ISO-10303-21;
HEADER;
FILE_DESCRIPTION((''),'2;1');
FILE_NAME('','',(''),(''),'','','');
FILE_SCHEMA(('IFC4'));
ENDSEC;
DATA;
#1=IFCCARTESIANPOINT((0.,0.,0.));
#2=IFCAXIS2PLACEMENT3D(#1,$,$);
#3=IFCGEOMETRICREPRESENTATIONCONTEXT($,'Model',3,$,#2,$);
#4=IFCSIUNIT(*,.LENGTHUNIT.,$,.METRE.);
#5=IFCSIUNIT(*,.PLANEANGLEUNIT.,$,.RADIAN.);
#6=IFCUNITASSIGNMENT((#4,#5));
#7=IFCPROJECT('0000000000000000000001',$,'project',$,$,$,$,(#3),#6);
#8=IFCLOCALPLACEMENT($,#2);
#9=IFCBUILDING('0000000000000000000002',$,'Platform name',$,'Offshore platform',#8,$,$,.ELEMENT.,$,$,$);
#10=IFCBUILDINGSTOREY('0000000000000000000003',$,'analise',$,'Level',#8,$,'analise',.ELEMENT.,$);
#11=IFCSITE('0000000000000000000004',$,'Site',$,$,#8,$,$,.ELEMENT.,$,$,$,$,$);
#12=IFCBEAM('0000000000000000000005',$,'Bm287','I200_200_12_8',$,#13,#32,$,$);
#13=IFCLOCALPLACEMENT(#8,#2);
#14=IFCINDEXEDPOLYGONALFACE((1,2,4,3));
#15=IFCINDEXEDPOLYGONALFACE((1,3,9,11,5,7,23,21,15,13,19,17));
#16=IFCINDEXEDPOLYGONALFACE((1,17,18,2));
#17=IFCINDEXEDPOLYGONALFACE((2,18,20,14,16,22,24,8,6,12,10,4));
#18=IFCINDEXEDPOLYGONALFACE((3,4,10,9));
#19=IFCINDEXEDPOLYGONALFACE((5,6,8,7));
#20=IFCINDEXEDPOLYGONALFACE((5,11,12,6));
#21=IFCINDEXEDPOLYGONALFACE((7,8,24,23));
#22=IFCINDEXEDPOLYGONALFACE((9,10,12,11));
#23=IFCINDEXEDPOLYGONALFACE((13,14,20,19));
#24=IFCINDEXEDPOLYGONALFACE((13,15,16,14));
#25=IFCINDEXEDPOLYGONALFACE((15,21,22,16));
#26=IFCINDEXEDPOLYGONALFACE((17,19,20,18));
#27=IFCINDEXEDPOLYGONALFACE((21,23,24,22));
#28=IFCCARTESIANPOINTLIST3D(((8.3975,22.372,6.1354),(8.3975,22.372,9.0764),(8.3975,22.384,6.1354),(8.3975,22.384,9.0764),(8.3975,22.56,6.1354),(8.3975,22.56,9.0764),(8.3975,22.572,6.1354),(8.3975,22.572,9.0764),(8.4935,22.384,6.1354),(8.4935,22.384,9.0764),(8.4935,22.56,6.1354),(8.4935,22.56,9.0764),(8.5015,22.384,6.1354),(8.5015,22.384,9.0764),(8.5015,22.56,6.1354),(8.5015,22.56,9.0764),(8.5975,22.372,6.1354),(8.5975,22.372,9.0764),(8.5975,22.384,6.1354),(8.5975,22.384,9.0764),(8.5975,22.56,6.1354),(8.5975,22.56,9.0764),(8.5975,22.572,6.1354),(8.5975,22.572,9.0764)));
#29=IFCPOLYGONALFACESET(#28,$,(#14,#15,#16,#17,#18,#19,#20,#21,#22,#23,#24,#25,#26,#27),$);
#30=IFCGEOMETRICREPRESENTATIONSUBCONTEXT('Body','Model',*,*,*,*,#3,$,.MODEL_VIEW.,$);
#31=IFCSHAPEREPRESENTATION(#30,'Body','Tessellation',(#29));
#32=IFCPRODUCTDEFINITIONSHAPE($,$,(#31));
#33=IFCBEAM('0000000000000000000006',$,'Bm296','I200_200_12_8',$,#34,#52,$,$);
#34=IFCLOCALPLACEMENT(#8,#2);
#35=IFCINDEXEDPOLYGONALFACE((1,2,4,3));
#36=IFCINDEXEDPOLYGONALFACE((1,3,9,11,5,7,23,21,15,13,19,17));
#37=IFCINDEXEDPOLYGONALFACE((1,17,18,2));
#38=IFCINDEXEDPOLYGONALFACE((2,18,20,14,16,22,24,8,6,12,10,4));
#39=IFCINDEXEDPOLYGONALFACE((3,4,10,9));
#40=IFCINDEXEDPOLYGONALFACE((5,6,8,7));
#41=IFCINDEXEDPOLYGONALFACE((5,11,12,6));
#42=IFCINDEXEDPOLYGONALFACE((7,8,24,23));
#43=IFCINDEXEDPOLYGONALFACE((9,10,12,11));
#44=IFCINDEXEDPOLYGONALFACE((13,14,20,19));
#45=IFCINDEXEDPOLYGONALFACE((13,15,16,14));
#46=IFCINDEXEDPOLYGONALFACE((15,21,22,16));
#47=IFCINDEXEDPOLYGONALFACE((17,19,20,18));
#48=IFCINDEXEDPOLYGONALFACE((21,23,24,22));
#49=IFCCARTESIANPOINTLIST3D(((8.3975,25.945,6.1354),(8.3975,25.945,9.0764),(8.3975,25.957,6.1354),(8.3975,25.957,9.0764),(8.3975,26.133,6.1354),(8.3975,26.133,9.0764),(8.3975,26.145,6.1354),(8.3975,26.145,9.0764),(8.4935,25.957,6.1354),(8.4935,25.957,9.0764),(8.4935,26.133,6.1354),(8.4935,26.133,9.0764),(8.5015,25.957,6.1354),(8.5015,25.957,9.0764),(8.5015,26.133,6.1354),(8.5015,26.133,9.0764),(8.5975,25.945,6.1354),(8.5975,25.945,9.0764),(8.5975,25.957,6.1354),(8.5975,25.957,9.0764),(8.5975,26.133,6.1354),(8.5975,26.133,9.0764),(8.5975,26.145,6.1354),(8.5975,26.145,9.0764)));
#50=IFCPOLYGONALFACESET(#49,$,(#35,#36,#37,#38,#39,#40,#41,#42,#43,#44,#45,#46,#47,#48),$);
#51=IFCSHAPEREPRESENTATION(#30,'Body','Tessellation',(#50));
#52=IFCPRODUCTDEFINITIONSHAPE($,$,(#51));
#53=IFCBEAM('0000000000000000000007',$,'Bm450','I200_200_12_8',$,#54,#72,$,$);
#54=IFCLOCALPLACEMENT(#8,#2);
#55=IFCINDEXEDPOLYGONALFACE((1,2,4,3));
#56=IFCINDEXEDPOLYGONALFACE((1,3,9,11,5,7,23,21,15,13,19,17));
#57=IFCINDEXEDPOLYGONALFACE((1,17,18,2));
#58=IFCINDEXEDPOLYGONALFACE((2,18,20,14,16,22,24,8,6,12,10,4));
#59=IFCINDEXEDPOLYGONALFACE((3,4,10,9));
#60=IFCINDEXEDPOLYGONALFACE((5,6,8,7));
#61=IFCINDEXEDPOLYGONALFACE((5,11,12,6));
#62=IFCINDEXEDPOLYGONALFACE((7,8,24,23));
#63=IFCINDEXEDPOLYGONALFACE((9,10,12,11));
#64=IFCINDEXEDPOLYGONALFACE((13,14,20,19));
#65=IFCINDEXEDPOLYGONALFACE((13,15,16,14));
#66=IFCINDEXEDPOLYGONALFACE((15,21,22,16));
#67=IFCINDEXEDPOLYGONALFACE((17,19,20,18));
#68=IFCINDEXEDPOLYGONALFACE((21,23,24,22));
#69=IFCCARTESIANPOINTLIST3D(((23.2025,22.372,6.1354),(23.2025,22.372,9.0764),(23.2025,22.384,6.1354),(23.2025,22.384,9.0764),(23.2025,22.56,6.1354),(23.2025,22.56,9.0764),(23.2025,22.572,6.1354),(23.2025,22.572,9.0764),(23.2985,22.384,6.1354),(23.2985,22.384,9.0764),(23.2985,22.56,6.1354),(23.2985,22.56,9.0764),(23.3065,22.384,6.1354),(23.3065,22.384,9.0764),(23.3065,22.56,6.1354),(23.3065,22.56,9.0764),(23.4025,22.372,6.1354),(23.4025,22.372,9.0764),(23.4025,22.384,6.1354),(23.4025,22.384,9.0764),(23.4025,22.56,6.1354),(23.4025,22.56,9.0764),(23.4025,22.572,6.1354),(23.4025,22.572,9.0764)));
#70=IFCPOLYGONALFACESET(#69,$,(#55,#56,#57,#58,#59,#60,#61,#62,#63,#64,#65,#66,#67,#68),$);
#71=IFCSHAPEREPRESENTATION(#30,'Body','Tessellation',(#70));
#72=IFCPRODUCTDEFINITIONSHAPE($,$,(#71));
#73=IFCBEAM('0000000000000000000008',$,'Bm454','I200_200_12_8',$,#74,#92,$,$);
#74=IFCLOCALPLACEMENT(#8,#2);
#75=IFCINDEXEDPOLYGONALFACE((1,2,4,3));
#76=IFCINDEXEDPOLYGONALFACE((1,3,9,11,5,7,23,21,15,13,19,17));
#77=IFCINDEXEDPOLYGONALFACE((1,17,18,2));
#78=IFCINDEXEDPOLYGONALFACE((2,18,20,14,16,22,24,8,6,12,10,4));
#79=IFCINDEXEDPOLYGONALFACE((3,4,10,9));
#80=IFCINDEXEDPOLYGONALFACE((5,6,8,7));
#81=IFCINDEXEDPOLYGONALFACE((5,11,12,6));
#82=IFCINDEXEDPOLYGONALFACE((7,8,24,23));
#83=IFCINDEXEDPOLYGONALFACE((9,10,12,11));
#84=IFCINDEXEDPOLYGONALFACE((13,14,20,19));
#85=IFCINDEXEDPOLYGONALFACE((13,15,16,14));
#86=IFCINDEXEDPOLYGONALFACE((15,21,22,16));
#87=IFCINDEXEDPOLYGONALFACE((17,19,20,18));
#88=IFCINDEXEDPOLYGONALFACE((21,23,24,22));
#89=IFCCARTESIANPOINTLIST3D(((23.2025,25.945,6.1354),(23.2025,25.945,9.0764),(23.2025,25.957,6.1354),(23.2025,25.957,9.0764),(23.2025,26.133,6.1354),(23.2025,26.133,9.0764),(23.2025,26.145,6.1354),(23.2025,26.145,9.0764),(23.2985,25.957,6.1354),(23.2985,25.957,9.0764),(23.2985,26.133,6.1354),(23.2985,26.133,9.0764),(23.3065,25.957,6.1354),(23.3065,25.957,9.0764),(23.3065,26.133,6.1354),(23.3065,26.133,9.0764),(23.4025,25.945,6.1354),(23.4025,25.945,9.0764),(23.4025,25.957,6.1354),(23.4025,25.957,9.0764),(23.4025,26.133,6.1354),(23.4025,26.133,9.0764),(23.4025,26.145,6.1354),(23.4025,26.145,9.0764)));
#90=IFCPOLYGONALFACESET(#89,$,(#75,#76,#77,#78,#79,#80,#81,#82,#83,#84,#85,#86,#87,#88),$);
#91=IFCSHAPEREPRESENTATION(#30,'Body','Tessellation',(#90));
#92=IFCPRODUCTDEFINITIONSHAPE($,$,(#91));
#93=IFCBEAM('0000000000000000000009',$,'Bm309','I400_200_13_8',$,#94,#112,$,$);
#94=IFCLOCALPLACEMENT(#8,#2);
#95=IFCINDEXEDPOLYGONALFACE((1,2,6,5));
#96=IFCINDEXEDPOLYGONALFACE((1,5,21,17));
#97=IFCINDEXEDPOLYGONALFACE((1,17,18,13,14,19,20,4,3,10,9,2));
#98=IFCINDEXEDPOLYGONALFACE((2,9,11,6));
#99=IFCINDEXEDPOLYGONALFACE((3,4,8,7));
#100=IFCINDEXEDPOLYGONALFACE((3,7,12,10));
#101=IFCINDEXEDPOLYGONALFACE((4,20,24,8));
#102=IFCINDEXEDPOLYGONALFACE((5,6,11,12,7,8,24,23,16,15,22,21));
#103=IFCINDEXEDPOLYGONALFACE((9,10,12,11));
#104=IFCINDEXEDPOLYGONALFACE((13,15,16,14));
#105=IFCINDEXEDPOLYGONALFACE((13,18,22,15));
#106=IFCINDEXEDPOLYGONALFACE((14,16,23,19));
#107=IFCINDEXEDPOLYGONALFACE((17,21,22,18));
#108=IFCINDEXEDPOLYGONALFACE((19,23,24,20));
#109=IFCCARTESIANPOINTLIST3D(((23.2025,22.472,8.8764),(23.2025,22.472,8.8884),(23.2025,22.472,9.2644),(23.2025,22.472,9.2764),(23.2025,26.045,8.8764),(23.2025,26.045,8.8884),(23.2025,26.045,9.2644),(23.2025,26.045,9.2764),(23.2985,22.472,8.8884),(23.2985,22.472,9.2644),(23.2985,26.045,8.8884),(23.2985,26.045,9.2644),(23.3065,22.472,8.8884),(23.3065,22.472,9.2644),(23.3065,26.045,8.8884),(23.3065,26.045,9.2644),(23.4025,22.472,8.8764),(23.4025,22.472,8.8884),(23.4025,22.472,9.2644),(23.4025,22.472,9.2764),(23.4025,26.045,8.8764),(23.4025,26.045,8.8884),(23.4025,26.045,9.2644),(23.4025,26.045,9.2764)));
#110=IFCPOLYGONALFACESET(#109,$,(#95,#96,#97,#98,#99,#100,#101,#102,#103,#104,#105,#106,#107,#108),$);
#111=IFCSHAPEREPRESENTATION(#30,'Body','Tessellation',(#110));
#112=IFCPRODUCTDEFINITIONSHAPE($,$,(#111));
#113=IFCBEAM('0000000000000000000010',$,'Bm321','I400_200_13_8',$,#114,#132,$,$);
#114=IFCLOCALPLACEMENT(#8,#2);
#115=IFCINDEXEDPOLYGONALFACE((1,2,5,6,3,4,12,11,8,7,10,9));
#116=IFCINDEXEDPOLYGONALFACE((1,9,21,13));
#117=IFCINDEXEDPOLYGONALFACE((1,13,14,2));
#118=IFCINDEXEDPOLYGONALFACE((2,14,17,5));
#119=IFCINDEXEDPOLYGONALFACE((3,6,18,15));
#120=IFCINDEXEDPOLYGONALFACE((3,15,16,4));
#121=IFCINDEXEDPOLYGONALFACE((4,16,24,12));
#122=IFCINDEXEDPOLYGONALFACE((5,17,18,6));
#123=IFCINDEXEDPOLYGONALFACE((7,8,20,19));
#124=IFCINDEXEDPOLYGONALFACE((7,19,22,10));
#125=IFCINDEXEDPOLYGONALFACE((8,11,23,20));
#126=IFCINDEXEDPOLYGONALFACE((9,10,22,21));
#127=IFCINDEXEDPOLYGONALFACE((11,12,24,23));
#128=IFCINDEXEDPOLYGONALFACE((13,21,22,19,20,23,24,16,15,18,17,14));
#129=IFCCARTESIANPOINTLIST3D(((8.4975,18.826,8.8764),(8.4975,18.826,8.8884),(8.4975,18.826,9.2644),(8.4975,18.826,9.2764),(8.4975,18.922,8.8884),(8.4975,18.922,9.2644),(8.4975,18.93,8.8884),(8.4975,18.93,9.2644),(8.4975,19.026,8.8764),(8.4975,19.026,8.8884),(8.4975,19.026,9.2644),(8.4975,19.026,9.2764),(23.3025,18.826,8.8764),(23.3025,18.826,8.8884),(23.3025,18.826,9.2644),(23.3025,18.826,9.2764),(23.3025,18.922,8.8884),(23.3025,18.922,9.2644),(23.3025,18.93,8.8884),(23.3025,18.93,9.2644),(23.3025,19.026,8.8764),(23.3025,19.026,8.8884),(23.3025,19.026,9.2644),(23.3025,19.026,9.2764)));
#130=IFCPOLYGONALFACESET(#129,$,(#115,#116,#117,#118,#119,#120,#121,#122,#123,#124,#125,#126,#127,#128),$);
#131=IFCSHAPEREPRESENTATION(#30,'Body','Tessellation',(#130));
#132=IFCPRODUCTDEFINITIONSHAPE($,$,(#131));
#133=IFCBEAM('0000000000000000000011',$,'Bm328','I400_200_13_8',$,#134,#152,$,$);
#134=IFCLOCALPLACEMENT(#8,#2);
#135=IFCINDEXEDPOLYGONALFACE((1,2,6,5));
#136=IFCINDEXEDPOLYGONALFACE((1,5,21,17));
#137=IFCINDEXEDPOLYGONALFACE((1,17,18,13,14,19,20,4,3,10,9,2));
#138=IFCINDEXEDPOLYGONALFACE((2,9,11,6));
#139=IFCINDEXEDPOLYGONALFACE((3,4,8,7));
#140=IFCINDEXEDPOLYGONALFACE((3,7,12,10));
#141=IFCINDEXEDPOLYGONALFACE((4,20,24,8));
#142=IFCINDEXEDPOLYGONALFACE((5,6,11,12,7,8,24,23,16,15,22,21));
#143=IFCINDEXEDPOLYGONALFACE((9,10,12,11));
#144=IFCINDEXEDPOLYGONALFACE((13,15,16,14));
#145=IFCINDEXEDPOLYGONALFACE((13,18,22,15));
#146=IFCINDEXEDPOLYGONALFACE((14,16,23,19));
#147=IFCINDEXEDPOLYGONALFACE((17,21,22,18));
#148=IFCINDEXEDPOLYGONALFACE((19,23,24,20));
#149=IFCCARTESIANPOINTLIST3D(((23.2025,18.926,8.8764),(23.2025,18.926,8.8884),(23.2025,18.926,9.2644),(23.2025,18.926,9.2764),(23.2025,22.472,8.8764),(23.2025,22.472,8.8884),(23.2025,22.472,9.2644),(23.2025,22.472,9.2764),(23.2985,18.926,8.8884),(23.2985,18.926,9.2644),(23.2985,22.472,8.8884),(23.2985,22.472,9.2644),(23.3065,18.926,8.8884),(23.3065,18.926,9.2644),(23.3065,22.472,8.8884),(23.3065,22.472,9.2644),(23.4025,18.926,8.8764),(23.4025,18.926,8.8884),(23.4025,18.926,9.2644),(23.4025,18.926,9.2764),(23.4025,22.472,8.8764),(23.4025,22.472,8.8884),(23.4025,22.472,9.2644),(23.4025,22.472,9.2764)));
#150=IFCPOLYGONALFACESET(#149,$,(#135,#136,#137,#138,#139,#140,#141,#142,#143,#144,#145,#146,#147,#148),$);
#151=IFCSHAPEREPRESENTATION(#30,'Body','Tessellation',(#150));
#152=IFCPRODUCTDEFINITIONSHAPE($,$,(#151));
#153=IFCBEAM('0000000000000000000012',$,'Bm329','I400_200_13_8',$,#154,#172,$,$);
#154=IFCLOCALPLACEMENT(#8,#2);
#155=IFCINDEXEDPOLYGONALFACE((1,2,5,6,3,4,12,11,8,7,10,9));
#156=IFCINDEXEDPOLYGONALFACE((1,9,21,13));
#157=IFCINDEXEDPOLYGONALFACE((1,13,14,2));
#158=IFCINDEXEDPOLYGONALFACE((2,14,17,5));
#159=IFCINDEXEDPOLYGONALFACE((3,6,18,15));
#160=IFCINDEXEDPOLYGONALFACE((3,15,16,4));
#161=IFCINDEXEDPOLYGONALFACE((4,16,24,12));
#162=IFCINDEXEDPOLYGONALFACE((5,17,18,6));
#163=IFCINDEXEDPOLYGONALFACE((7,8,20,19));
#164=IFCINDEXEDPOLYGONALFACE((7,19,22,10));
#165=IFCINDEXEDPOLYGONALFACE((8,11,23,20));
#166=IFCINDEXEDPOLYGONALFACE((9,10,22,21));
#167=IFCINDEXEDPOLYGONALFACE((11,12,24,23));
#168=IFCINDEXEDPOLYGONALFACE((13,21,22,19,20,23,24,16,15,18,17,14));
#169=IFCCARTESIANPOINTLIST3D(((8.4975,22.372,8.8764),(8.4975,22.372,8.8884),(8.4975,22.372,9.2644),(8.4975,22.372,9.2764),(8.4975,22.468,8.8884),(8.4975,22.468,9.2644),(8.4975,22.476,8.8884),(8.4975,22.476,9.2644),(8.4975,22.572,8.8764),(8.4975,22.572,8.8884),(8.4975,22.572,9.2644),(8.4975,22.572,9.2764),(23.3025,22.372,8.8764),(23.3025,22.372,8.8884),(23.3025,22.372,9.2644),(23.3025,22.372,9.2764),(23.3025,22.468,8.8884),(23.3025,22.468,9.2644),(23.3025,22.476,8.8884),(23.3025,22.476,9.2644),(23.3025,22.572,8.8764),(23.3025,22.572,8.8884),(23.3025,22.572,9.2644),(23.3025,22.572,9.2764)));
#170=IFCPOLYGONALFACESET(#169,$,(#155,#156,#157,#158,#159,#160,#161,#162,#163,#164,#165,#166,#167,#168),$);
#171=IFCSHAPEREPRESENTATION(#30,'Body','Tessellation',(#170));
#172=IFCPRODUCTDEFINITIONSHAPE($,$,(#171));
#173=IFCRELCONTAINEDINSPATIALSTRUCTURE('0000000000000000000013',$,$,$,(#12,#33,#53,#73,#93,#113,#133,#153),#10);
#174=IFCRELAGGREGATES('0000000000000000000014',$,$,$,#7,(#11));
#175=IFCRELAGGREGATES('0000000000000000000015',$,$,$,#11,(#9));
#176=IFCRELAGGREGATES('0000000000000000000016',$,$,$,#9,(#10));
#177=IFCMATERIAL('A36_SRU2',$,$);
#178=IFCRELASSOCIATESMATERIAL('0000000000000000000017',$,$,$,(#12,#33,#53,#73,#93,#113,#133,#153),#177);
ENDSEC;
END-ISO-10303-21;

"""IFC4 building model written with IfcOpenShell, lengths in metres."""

from ifc_helpers import new_model, si_unit, frame, origin, origin_with_axes, origin_2d, place, context, subcontext, project, spatial, i_section, extrude, source, transform, mapped, material, element, save


model = new_model("IFC4")

# Units and contexts
model_context = context("Model", 3, world=origin())
body_context = subcontext(model_context, "Body", "Model", "MODEL_VIEW")
ifc_project = project(units=[si_unit("LENGTHUNIT", "METRE"), si_unit("PLANEANGLEUNIT", "RADIAN")], contexts=[model_context])

# Site, building, storey
placement_1 = place(None, origin())
site = spatial("IfcSite", under=ifc_project, at=placement_1, Name="Site", CompositionType="ELEMENT")
building = spatial("IfcBuilding", under=site, at=placement_1, Name="Platform name", ObjectType="Offshore platform", CompositionType="ELEMENT")
storey = spatial("IfcBuildingStorey", under=building, at=placement_1, Name="analise", ObjectType="Level", LongName="analise", CompositionType="ELEMENT")

# Beams
ifc_material_1 = material(Name="A36_SRU2")
shared_shape_1 = source(origin(), body_context, "Body", "SweptSolid", [
    extrude(i_section(OverallWidth=0.2, OverallDepth=0.2, WebThickness=0.008, FlangeThickness=0.012, FilletRadius=0.0, at=origin_2d()), origin_with_axes(), (0.0, 0.0, 1.0), 2.941),
])
placement_2 = place(None, origin())
placement_3 = place(placement_2, origin())
placement_4 = place(placement_3, origin())
beam_1_placement = place(placement_4, frame((8.4975, 22.472, 6.1354)))
element("IfcBeam", 1, at=beam_1_placement, inside=storey, material=ifc_material_1, Name="Bm287", Description="I200_200_12_8", context=body_context, shape_type="MappedRepresentation", body=[
    mapped(shared_shape_1, transform((0.0, 0.0, 0.0), scale=1.0)),
])
shared_shape_2 = source(origin(), body_context, "Body", "SweptSolid", [
    extrude(i_section(OverallWidth=0.2, OverallDepth=0.2, WebThickness=0.008, FlangeThickness=0.012, FilletRadius=0.0, at=origin_2d()), origin_with_axes(), (0.0, 0.0, 1.0), 2.941),
])
placement_5 = place(None, origin())
placement_6 = place(placement_5, origin())
placement_7 = place(placement_6, origin())
beam_2_placement = place(placement_7, frame((8.4975, 26.045, 6.1354)))
element("IfcBeam", 2, at=beam_2_placement, inside=storey, material=ifc_material_1, Name="Bm296", Description="I200_200_12_8", context=body_context, shape_type="MappedRepresentation", body=[
    mapped(shared_shape_2, transform((0.0, 0.0, 0.0), scale=1.0)),
])
shared_shape_3 = source(origin(), body_context, "Body", "SweptSolid", [
    extrude(i_section(OverallWidth=0.2, OverallDepth=0.2, WebThickness=0.008, FlangeThickness=0.012, FilletRadius=0.0, at=origin_2d()), origin_with_axes(), (0.0, 0.0, 1.0), 2.941),
])
placement_8 = place(None, origin())
placement_9 = place(placement_8, origin())
placement_10 = place(placement_9, origin())
beam_3_placement = place(placement_10, frame((23.3025, 22.472, 6.1354)))
element("IfcBeam", 3, at=beam_3_placement, inside=storey, material=ifc_material_1, Name="Bm450", Description="I200_200_12_8", context=body_context, shape_type="MappedRepresentation", body=[
    mapped(shared_shape_3, transform((0.0, 0.0, 0.0), scale=1.0)),
])
shared_shape_4 = source(origin(), body_context, "Body", "SweptSolid", [
    extrude(i_section(OverallWidth=0.2, OverallDepth=0.2, WebThickness=0.008, FlangeThickness=0.012, FilletRadius=0.0, at=origin_2d()), origin_with_axes(), (0.0, 0.0, 1.0), 2.941),
])
placement_11 = place(None, origin())
placement_12 = place(placement_11, origin())
placement_13 = place(placement_12, origin())
beam_4_placement = place(placement_13, frame((23.3025, 26.045, 6.1354)))
element("IfcBeam", 4, at=beam_4_placement, inside=storey, material=ifc_material_1, Name="Bm454", Description="I200_200_12_8", context=body_context, shape_type="MappedRepresentation", body=[
    mapped(shared_shape_4, transform((0.0, 0.0, 0.0), scale=1.0)),
])
shared_shape_5 = source(origin(), body_context, "Body", "SweptSolid", [
    extrude(i_section(OverallWidth=0.2, OverallDepth=0.4, WebThickness=0.008, FlangeThickness=0.012, FilletRadius=0.0, at=origin_2d()), frame((0.0, 0.0, 0.0), z_axis=(0.0, 1.0, 0.0), x_axis=(-1.0, 0.0, 0.0)), (0.0, 0.0, 1.0), 3.573),
])
placement_14 = place(None, origin())
placement_15 = place(placement_14, origin())
placement_16 = place(placement_15, origin())
beam_5_placement = place(placement_16, frame((23.3025, 22.472, 9.0764)))
element("IfcBeam", 5, at=beam_5_placement, inside=storey, material=ifc_material_1, Name="Bm309", Description="I400_200_13_8", context=body_context, shape_type="MappedRepresentation", body=[
    mapped(shared_shape_5, transform((0.0, 0.0, 0.0), scale=1.0)),
])
shared_shape_6 = source(origin(), body_context, "Body", "SweptSolid", [
    extrude(i_section(OverallWidth=0.2, OverallDepth=0.4, WebThickness=0.008, FlangeThickness=0.012, FilletRadius=0.0, at=origin_2d()), frame((0.0, 0.0, 0.0), z_axis=(-1.0, 0.0, 0.0), x_axis=(0.0, -1.0, 0.0)), (0.0, 0.0, 1.0), 14.805),
])
placement_17 = place(None, origin())
placement_18 = place(placement_17, origin())
placement_19 = place(placement_18, origin())
beam_6_placement = place(placement_19, frame((23.3025, 18.926, 9.0764)))
element("IfcBeam", 6, at=beam_6_placement, inside=storey, material=ifc_material_1, Name="Bm321", Description="I400_200_13_8", context=body_context, shape_type="MappedRepresentation", body=[
    mapped(shared_shape_6, transform((0.0, 0.0, 0.0), scale=1.0)),
])
shared_shape_7 = source(origin(), body_context, "Body", "SweptSolid", [
    extrude(i_section(OverallWidth=0.2, OverallDepth=0.4, WebThickness=0.008, FlangeThickness=0.012, FilletRadius=0.0, at=origin_2d()), frame((0.0, 0.0, 0.0), z_axis=(0.0, 1.0, 0.0), x_axis=(-1.0, 0.0, 0.0)), (0.0, 0.0, 1.0), 3.546),
])
placement_20 = place(None, origin())
placement_21 = place(placement_20, origin())
placement_22 = place(placement_21, origin())
beam_7_placement = place(placement_22, frame((23.3025, 18.926, 9.0764)))
element("IfcBeam", 7, at=beam_7_placement, inside=storey, material=ifc_material_1, Name="Bm328", Description="I400_200_13_8", context=body_context, shape_type="MappedRepresentation", body=[
    mapped(shared_shape_7, transform((0.0, 0.0, 0.0), scale=1.0)),
])
shared_shape_8 = source(origin(), body_context, "Body", "SweptSolid", [
    extrude(i_section(OverallWidth=0.2, OverallDepth=0.4, WebThickness=0.008, FlangeThickness=0.012, FilletRadius=0.0, at=origin_2d()), frame((0.0, 0.0, 0.0), z_axis=(-1.0, 0.0, 0.0), x_axis=(0.0, -1.0, 0.0)), (0.0, 0.0, 1.0), 14.805),
])
placement_23 = place(None, origin())
placement_24 = place(placement_23, origin())
placement_25 = place(placement_24, origin())
beam_8_placement = place(placement_25, frame((23.3025, 22.472, 9.0764)))
element("IfcBeam", 8, at=beam_8_placement, inside=storey, material=ifc_material_1, Name="Bm329", Description="I400_200_13_8", context=body_context, shape_type="MappedRepresentation", body=[
    mapped(shared_shape_8, transform((0.0, 0.0, 0.0), scale=1.0)),
])

save(model, "model.ifc")
